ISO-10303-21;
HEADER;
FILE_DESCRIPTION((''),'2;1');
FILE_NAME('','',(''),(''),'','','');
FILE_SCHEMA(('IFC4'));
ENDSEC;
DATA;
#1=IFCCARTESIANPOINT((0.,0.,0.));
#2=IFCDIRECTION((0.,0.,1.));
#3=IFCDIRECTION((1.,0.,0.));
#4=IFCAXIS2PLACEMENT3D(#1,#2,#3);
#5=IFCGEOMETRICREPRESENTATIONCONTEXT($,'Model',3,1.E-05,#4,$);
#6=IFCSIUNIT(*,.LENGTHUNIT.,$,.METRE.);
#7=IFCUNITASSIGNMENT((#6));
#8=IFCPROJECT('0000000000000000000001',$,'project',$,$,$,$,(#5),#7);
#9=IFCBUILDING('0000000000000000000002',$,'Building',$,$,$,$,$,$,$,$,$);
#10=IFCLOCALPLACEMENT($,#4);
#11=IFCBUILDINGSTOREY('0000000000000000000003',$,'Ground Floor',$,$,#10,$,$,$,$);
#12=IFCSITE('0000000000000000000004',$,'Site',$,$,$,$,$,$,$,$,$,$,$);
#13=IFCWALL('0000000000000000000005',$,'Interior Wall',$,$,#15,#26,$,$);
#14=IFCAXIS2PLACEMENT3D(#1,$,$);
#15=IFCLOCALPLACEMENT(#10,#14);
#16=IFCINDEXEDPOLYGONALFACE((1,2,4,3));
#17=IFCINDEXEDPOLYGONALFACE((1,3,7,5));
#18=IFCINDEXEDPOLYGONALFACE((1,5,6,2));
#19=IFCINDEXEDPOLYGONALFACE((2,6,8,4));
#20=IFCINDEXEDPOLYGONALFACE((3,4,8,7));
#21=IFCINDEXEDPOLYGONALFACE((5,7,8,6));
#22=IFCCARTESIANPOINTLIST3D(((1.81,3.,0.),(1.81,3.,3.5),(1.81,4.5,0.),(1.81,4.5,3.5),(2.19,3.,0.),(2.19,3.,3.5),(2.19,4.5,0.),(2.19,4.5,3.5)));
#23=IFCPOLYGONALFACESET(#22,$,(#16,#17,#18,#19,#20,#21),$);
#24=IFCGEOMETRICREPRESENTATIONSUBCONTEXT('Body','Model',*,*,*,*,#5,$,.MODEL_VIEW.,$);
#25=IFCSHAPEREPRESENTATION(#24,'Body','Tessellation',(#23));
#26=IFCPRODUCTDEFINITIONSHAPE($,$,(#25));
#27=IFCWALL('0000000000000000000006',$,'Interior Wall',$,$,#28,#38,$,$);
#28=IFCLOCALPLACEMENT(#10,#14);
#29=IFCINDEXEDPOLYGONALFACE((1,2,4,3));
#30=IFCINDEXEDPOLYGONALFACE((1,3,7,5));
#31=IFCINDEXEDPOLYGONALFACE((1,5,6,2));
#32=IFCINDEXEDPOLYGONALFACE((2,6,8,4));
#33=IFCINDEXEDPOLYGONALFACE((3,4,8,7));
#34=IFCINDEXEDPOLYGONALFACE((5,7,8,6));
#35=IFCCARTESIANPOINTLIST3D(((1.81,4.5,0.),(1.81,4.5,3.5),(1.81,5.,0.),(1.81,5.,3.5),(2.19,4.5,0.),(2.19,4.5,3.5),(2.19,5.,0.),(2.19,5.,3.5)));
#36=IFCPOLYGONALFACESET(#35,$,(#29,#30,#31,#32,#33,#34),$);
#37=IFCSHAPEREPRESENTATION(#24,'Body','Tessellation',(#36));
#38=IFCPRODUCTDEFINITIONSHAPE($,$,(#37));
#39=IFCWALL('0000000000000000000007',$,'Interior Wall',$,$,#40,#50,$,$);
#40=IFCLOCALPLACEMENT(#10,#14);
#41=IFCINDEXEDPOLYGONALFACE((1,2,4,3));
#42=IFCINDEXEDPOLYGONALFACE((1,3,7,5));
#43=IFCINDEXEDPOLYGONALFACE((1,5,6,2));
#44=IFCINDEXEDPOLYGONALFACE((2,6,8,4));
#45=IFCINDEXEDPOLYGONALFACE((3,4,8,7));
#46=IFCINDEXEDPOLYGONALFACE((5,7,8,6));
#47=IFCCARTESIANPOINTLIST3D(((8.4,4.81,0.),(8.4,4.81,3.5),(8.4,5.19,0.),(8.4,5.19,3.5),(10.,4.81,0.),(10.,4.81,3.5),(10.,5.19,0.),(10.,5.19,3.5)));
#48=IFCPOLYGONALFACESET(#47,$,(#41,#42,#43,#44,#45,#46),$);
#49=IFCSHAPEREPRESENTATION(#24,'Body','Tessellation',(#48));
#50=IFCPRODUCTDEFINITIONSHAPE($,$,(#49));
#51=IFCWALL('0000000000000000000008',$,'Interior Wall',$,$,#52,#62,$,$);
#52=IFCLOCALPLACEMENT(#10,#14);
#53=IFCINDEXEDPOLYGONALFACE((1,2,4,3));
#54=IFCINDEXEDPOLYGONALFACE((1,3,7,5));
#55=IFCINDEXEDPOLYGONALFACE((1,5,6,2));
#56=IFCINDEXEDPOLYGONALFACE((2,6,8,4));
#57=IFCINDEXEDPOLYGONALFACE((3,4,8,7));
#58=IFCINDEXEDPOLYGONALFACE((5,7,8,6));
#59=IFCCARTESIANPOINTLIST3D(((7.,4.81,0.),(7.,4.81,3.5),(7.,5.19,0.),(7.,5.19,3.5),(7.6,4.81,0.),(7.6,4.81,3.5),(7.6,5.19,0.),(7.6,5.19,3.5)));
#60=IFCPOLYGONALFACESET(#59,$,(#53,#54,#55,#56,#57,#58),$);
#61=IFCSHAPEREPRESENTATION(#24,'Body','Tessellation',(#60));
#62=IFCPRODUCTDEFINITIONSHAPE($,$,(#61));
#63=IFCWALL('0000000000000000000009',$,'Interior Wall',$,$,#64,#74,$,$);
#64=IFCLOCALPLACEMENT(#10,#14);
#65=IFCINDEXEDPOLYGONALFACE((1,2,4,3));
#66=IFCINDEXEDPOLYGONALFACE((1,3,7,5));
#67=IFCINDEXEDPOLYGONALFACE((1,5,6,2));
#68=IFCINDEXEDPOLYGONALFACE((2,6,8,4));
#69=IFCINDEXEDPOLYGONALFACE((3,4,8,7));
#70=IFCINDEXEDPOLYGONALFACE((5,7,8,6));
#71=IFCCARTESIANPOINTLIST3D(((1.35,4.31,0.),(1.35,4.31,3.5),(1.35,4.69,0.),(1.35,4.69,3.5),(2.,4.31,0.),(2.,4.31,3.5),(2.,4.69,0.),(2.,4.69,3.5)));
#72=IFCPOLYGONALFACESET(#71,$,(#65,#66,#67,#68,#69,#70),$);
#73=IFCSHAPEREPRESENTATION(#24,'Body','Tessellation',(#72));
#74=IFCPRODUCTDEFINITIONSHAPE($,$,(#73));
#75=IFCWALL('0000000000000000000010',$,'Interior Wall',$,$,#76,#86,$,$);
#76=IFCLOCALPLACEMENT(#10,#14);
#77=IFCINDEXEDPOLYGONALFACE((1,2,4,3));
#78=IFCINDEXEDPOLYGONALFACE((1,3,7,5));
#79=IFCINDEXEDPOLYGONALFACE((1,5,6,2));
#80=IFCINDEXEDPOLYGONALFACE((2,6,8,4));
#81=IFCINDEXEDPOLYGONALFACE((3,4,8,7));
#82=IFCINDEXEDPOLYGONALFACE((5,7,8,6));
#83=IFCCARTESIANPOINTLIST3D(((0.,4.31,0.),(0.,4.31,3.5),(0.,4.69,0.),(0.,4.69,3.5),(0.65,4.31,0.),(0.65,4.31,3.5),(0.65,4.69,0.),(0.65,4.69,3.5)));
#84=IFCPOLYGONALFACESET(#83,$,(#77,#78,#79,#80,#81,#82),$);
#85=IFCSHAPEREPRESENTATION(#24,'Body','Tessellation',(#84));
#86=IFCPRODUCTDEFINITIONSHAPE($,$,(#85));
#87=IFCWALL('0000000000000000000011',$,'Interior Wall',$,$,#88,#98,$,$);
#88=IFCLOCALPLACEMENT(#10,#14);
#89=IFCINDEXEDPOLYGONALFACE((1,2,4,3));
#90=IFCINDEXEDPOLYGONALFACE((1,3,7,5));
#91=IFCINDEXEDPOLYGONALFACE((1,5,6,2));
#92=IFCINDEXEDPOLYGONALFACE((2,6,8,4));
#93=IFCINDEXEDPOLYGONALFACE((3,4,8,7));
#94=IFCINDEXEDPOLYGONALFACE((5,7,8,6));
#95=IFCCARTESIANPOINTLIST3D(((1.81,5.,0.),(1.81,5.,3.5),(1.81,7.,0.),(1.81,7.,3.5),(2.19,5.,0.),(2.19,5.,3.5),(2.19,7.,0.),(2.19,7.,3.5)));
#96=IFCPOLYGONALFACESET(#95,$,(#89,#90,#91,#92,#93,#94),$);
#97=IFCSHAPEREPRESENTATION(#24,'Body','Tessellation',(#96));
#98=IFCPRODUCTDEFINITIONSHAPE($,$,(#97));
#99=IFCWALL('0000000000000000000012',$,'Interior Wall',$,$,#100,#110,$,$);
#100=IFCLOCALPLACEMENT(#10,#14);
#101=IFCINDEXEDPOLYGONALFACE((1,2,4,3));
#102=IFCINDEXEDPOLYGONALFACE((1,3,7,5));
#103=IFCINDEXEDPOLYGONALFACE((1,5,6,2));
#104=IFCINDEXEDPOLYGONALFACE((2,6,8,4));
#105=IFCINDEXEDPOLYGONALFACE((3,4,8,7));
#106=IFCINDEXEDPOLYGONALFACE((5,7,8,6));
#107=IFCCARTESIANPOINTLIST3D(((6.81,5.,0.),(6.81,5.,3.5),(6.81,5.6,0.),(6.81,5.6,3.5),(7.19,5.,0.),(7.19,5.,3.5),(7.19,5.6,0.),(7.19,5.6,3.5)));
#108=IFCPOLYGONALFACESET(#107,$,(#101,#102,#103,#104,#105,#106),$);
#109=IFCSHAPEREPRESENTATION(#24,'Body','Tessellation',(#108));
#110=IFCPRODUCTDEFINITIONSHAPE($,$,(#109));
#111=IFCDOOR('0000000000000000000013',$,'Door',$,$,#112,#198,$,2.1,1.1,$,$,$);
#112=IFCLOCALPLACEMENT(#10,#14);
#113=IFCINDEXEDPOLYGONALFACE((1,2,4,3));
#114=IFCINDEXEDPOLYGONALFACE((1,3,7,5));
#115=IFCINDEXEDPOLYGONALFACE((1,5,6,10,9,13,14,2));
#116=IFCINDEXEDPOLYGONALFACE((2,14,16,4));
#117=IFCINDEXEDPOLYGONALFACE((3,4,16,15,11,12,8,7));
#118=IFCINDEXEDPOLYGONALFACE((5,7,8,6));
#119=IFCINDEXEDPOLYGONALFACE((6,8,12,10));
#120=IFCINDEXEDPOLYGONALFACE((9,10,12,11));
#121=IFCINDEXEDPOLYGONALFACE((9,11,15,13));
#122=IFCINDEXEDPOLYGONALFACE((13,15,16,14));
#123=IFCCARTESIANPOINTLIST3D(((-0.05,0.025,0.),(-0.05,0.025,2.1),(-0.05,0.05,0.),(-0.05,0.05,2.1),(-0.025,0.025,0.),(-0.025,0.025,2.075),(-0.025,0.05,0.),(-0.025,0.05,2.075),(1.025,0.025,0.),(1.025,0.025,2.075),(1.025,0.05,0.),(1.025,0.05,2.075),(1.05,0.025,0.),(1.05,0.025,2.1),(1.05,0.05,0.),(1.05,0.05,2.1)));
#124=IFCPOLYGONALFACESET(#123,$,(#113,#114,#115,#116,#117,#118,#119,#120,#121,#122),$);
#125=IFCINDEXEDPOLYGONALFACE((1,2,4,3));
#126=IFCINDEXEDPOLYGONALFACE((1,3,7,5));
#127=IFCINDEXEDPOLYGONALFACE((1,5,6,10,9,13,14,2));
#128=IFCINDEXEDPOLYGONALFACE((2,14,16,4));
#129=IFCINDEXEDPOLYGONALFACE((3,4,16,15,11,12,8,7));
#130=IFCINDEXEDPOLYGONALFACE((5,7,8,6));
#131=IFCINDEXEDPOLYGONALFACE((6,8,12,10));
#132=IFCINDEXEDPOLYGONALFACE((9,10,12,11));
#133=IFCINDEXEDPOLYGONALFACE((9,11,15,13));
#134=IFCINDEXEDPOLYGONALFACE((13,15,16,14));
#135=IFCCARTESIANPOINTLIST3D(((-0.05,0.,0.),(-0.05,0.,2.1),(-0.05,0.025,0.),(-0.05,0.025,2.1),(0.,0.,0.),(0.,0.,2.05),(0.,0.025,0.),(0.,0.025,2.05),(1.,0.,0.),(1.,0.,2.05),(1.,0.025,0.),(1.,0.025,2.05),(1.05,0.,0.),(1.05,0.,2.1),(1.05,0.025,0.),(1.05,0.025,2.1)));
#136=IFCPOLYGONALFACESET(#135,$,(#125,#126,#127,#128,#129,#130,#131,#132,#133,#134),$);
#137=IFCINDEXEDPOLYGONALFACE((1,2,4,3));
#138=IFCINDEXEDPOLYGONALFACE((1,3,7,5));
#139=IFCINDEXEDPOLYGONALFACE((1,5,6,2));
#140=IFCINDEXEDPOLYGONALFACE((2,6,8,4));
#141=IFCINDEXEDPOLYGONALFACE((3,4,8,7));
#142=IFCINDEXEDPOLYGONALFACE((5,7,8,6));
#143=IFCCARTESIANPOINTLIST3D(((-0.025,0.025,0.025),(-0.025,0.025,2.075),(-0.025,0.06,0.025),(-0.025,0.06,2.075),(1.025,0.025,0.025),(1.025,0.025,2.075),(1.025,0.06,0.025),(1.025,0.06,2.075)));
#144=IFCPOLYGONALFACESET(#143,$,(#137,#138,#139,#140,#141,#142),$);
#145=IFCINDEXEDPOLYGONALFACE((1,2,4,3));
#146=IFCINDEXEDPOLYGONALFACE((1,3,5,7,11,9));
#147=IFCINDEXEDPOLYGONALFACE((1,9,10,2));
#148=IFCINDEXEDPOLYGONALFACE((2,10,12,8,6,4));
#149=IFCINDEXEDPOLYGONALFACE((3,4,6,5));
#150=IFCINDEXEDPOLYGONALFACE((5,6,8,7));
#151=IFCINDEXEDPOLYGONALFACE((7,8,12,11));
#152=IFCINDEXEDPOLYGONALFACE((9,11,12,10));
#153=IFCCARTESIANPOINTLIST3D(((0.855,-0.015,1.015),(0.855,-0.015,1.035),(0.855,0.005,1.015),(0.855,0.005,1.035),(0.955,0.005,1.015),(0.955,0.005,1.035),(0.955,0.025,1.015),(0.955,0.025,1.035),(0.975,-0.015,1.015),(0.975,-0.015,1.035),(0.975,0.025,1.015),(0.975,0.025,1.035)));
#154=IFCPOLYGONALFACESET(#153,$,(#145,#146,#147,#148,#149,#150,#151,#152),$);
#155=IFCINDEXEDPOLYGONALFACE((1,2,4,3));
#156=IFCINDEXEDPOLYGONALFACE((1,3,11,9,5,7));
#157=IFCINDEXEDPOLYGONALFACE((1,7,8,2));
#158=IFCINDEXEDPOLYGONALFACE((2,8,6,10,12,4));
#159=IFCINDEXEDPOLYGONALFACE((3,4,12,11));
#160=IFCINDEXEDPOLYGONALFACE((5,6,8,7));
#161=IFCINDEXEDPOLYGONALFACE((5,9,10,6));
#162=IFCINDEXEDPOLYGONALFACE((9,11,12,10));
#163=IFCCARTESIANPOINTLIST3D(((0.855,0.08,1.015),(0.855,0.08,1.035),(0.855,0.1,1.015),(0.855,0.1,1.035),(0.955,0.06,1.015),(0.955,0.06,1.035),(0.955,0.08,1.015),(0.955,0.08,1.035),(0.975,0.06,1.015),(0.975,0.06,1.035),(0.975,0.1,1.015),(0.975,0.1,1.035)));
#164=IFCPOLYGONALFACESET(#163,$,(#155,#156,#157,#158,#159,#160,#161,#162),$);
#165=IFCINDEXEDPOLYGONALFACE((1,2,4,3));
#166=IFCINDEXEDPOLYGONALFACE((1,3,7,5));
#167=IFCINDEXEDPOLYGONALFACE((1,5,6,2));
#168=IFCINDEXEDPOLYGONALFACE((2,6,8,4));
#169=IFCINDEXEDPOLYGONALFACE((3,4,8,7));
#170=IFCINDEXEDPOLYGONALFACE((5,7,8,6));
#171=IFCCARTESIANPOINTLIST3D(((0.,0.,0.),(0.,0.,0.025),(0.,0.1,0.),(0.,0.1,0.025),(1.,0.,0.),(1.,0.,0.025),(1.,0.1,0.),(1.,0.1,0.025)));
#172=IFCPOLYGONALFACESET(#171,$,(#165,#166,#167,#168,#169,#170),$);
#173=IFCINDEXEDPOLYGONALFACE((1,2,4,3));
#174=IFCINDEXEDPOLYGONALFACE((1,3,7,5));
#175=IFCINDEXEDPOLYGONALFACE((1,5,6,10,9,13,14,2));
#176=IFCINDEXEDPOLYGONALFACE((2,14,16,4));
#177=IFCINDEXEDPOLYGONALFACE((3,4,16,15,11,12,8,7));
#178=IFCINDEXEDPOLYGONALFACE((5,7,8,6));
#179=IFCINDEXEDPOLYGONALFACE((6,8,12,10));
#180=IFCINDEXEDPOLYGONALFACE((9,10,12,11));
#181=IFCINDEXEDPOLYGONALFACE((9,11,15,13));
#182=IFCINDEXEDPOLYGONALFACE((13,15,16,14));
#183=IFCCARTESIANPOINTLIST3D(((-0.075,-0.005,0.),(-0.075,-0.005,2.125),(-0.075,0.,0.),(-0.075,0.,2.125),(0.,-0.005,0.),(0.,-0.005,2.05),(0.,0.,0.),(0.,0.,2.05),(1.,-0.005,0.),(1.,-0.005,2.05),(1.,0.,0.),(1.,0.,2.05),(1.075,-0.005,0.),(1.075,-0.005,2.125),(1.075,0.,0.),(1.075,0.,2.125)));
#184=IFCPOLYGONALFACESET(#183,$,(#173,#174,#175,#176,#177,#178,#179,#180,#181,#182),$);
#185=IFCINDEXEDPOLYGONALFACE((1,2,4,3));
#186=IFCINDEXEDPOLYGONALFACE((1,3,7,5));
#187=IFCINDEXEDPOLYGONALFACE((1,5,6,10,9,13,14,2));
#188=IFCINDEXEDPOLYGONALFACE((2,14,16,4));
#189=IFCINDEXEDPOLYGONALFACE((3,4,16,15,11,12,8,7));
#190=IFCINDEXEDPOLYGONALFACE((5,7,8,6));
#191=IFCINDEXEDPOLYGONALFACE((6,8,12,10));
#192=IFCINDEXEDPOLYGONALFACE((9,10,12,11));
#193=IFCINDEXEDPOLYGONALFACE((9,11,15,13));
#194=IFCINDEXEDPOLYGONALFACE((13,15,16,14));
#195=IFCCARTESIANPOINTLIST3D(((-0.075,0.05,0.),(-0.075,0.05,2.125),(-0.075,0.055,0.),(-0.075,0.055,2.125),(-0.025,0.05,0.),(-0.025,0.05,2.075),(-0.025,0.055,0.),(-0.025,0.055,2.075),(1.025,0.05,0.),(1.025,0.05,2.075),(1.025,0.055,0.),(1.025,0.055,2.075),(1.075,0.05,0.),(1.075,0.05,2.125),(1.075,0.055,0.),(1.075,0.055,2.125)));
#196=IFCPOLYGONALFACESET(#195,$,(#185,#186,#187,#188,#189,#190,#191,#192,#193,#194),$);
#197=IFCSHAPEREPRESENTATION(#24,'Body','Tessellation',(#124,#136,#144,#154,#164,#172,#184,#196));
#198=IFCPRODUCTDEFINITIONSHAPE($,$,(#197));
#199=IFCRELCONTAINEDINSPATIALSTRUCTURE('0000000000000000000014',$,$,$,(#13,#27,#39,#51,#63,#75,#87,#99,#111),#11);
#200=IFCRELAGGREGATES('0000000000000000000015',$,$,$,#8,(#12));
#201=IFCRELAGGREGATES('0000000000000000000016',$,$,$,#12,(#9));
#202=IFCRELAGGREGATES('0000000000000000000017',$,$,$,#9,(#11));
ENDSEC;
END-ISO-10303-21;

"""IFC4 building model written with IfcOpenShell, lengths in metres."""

from ifc_helpers import new_model, si_unit, frame, origin_with_axes, place, context, subcontext, project, spatial, line, indexed_curve, outline, extrude, element, save


model = new_model("IFC4")

# Units and contexts
model_context = context("Model", 3, precision=1e-05, world=origin_with_axes())
body_context = subcontext(model_context, "Body", "Model", "MODEL_VIEW")
ifc_project = project(units=[si_unit("LENGTHUNIT", "METRE")], contexts=[model_context])

# Site, building, storey
site = spatial("IfcSite", under=ifc_project, Name="Site")
building = spatial("IfcBuilding", under=site, Name="Building")
storey_placement = place(None, origin_with_axes())
storey = spatial("IfcBuildingStorey", under=building, at=storey_placement, Name="Ground Floor")

# Walls
wall_1_placement = place(storey_placement, frame((2.0, 4.5, 0.0), z_axis=(0.0, 0.0, 1.0), x_axis=(0.0, -1.0, 0.0)))
element("IfcWall", 1, at=wall_1_placement, inside=storey, Name="Interior Wall", context=body_context, shape_type="SweptSolid", body=[
    extrude(outline(indexed_curve([(0.0, 0.0), (0.0, 0.38), (1.5, 0.38), (1.5, 0.0), (0.0, 0.0)], self_intersect=False)), frame((0.0, -0.19, 0.0), z_axis=(0.0, 0.0, 1.0), x_axis=(1.0, 0.0, 0.0)), (0.0, 0.0, 1.0), 3.5),
])
wall_2_placement = place(storey_placement, frame((2.0, 5.0, 0.0), z_axis=(0.0, 0.0, 1.0), x_axis=(0.0, -1.0, 0.0)))
element("IfcWall", 2, at=wall_2_placement, inside=storey, Name="Interior Wall", context=body_context, shape_type="SweptSolid", body=[
    extrude(outline(indexed_curve([(0.0, 0.0), (0.0, 0.38), (0.5, 0.38), (0.5, 0.0), (0.0, 0.0)], self_intersect=False)), frame((0.0, -0.19, 0.0), z_axis=(0.0, 0.0, 1.0), x_axis=(1.0, 0.0, 0.0)), (0.0, 0.0, 1.0), 3.5),
])
wall_3_placement = place(storey_placement, frame((10.0, 5.0, 0.0), z_axis=(0.0, 0.0, 1.0), x_axis=(-1.0, 0.0, 0.0)))
element("IfcWall", 3, at=wall_3_placement, inside=storey, Name="Interior Wall", context=body_context, shape_type="SweptSolid", body=[
    extrude(outline(indexed_curve([(0.0, 0.0), (0.0, 0.38), (1.6, 0.38), (1.6, 0.0), (0.0, 0.0)], self_intersect=False)), frame((0.0, -0.19, 0.0), z_axis=(0.0, 0.0, 1.0), x_axis=(1.0, 0.0, 0.0)), (0.0, 0.0, 1.0), 3.5),
])
wall_4_placement = place(storey_placement, frame((7.6, 5.0, 0.0), z_axis=(0.0, 0.0, 1.0), x_axis=(-1.0, 0.0, 0.0)))
element("IfcWall", 4, at=wall_4_placement, inside=storey, Name="Interior Wall", context=body_context, shape_type="SweptSolid", body=[
    extrude(outline(indexed_curve([(0.0, 0.0), (0.0, 0.38), (0.6, 0.38), (0.6, 0.0), (0.0, 0.0)], self_intersect=False)), frame((0.0, -0.19, 0.0), z_axis=(0.0, 0.0, 1.0), x_axis=(1.0, 0.0, 0.0)), (0.0, 0.0, 1.0), 3.5),
])
for number, where, z_axis, x_axis, name in (
    (5, (2.0, 4.5, 0.0), (0.0, 0.0, 1.0), (-1.0, 0.0, 0.0), "Interior Wall"),
    (6, (0.65, 4.5, 0.0), (0.0, 0.0, 1.0), (-1.0, 0.0, 0.0), "Interior Wall"),
):
    element("IfcWall", number, at=place(storey_placement, frame(where, z_axis=z_axis, x_axis=x_axis)), inside=storey, Name=name, context=body_context, shape_type="SweptSolid", body=[
        extrude(outline(indexed_curve([(0.0, 0.0), (0.0, 0.38), (0.65, 0.38), (0.65, 0.0), (0.0, 0.0)], self_intersect=False)), frame((0.0, -0.19, 0.0), z_axis=(0.0, 0.0, 1.0), x_axis=(1.0, 0.0, 0.0)), (0.0, 0.0, 1.0), 3.5),
    ])
wall_5_placement = place(storey_placement, frame((2.0, 5.0, 0.0), z_axis=(0.0, 0.0, 1.0), x_axis=(0.0, 1.0, 0.0)))
element("IfcWall", 7, at=wall_5_placement, inside=storey, Name="Interior Wall", context=body_context, shape_type="SweptSolid", body=[
    extrude(outline(indexed_curve([(0.0, 0.0), (0.0, 0.38), (2.0, 0.38), (2.0, 0.0), (0.0, 0.0)], self_intersect=False)), frame((0.0, -0.19, 0.0), z_axis=(0.0, 0.0, 1.0), x_axis=(1.0, 0.0, 0.0)), (0.0, 0.0, 1.0), 3.5),
])
wall_6_placement = place(storey_placement, frame((7.0, 5.6, 0.0), z_axis=(0.0, 0.0, 1.0), x_axis=(0.0, -1.0, 0.0)))
element("IfcWall", 8, at=wall_6_placement, inside=storey, Name="Interior Wall", context=body_context, shape_type="SweptSolid", body=[
    extrude(outline(indexed_curve([(0.0, 0.0), (0.0, 0.38), (0.6, 0.38), (0.6, 0.0), (0.0, 0.0)], self_intersect=False)), frame((0.0, -0.19, 0.0), z_axis=(0.0, 0.0, 1.0), x_axis=(1.0, 0.0, 0.0)), (0.0, 0.0, 1.0), 3.5),
])

# Door
door_1_placement = place(storey_placement, frame((-0.05, 0.0, 0.0), z_axis=(0.0, 0.0, 1.0), x_axis=(1.0, 0.0, 0.0)))
element("IfcDoor", 9, at=door_1_placement, inside=storey, Name="Door", OverallHeight=2.1, OverallWidth=1.1, context=body_context, shape_type="SweptSolid", body=[
    extrude(outline(indexed_curve([(0.0, 0.0), (0.0, 2.1), (1.1, 2.1), (1.1, 0.0), (1.075, 0.0), (1.075, 2.075), (0.025, 2.075), (0.025, 0.0)], segments=[line(1, 2, 3, 4, 5, 6, 7, 8, 1)])), frame((0.0, 0.025, 0.0), z_axis=(0.0, -1.0, 0.0), x_axis=(1.0, 0.0, 0.0)), (0.0, 0.0, -1.0), 0.025),
    extrude(outline(indexed_curve([(0.0, 0.0), (0.0, 2.1), (1.1, 2.1), (1.1, 0.0), (1.05, 0.0), (1.05, 2.05), (0.05, 2.05), (0.05, 0.0)], segments=[line(1, 2, 3, 4, 5, 6, 7, 8, 1)])), frame((0.0, 0.0, 0.0), z_axis=(0.0, -1.0, 0.0), x_axis=(1.0, 0.0, 0.0)), (0.0, 0.0, -1.0), 0.025),
    extrude(outline(indexed_curve([(0.0, 0.0), (1.05, 0.0), (1.05, 0.035), (0.0, 0.035)], segments=[line(1, 2, 3, 4, 1)])), frame((0.025, 0.025, 0.025), z_axis=(0.0, 0.0, 1.0), x_axis=(1.0, 0.0, 0.0)), (0.0, 0.0, 1.0), 2.05),
    extrude(outline(indexed_curve([(0.0, 0.0), (0.0, -0.04), (-0.12, -0.04), (-0.12, -0.02), (-0.02, -0.02), (-0.02, 0.0)], segments=[line(1, 2, 3, 4, 5, 6, 1)])), frame((1.025, 0.025, 1.015), z_axis=(0.0, 0.0, 1.0), x_axis=(1.0, 0.0, 0.0)), (0.0, 0.0, 1.0), 0.02),
    extrude(outline(indexed_curve([(0.0, 0.0), (0.0, 0.04), (-0.12, 0.04), (-0.12, 0.02), (-0.02, 0.02), (-0.02, 0.0)], segments=[line(1, 2, 3, 4, 5, 6, 1)])), frame((1.025, 0.06, 1.015), z_axis=(0.0, 0.0, 1.0), x_axis=(1.0, 0.0, 0.0)), (0.0, 0.0, 1.0), 0.02),
    extrude(outline(indexed_curve([(0.0, 0.0), (1.0, 0.0), (1.0, 0.1), (0.0, 0.1)], segments=[line(1, 2, 3, 4, 1)])), frame((0.05, 0.0, 0.0), z_axis=(0.0, 0.0, 1.0), x_axis=(1.0, 0.0, 0.0)), (0.0, 0.0, 1.0), 0.025),
    extrude(outline(indexed_curve([(0.0, 0.0), (0.0, 2.125), (1.15, 2.125), (1.15, 0.0), (1.075, 0.0), (1.075, 2.05), (0.075, 2.05), (0.075, 0.0)], segments=[line(1, 2, 3, 4, 5, 6, 7, 8, 1)])), frame((-0.025, -0.005, 0.0), z_axis=(0.0, -1.0, 0.0), x_axis=(1.0, 0.0, 0.0)), (0.0, 0.0, -1.0), 0.005),
    extrude(outline(indexed_curve([(0.0, 0.0), (0.0, 2.125), (1.15, 2.125), (1.15, 0.0), (1.1, 0.0), (1.1, 2.075), (0.05, 2.075), (0.05, 0.0)], segments=[line(1, 2, 3, 4, 5, 6, 7, 8, 1)])), frame((-0.025, 0.05, 0.0), z_axis=(0.0, -1.0, 0.0), x_axis=(1.0, 0.0, 0.0)), (0.0, 0.0, -1.0), 0.005),
])

save(model, "model.ifc")
